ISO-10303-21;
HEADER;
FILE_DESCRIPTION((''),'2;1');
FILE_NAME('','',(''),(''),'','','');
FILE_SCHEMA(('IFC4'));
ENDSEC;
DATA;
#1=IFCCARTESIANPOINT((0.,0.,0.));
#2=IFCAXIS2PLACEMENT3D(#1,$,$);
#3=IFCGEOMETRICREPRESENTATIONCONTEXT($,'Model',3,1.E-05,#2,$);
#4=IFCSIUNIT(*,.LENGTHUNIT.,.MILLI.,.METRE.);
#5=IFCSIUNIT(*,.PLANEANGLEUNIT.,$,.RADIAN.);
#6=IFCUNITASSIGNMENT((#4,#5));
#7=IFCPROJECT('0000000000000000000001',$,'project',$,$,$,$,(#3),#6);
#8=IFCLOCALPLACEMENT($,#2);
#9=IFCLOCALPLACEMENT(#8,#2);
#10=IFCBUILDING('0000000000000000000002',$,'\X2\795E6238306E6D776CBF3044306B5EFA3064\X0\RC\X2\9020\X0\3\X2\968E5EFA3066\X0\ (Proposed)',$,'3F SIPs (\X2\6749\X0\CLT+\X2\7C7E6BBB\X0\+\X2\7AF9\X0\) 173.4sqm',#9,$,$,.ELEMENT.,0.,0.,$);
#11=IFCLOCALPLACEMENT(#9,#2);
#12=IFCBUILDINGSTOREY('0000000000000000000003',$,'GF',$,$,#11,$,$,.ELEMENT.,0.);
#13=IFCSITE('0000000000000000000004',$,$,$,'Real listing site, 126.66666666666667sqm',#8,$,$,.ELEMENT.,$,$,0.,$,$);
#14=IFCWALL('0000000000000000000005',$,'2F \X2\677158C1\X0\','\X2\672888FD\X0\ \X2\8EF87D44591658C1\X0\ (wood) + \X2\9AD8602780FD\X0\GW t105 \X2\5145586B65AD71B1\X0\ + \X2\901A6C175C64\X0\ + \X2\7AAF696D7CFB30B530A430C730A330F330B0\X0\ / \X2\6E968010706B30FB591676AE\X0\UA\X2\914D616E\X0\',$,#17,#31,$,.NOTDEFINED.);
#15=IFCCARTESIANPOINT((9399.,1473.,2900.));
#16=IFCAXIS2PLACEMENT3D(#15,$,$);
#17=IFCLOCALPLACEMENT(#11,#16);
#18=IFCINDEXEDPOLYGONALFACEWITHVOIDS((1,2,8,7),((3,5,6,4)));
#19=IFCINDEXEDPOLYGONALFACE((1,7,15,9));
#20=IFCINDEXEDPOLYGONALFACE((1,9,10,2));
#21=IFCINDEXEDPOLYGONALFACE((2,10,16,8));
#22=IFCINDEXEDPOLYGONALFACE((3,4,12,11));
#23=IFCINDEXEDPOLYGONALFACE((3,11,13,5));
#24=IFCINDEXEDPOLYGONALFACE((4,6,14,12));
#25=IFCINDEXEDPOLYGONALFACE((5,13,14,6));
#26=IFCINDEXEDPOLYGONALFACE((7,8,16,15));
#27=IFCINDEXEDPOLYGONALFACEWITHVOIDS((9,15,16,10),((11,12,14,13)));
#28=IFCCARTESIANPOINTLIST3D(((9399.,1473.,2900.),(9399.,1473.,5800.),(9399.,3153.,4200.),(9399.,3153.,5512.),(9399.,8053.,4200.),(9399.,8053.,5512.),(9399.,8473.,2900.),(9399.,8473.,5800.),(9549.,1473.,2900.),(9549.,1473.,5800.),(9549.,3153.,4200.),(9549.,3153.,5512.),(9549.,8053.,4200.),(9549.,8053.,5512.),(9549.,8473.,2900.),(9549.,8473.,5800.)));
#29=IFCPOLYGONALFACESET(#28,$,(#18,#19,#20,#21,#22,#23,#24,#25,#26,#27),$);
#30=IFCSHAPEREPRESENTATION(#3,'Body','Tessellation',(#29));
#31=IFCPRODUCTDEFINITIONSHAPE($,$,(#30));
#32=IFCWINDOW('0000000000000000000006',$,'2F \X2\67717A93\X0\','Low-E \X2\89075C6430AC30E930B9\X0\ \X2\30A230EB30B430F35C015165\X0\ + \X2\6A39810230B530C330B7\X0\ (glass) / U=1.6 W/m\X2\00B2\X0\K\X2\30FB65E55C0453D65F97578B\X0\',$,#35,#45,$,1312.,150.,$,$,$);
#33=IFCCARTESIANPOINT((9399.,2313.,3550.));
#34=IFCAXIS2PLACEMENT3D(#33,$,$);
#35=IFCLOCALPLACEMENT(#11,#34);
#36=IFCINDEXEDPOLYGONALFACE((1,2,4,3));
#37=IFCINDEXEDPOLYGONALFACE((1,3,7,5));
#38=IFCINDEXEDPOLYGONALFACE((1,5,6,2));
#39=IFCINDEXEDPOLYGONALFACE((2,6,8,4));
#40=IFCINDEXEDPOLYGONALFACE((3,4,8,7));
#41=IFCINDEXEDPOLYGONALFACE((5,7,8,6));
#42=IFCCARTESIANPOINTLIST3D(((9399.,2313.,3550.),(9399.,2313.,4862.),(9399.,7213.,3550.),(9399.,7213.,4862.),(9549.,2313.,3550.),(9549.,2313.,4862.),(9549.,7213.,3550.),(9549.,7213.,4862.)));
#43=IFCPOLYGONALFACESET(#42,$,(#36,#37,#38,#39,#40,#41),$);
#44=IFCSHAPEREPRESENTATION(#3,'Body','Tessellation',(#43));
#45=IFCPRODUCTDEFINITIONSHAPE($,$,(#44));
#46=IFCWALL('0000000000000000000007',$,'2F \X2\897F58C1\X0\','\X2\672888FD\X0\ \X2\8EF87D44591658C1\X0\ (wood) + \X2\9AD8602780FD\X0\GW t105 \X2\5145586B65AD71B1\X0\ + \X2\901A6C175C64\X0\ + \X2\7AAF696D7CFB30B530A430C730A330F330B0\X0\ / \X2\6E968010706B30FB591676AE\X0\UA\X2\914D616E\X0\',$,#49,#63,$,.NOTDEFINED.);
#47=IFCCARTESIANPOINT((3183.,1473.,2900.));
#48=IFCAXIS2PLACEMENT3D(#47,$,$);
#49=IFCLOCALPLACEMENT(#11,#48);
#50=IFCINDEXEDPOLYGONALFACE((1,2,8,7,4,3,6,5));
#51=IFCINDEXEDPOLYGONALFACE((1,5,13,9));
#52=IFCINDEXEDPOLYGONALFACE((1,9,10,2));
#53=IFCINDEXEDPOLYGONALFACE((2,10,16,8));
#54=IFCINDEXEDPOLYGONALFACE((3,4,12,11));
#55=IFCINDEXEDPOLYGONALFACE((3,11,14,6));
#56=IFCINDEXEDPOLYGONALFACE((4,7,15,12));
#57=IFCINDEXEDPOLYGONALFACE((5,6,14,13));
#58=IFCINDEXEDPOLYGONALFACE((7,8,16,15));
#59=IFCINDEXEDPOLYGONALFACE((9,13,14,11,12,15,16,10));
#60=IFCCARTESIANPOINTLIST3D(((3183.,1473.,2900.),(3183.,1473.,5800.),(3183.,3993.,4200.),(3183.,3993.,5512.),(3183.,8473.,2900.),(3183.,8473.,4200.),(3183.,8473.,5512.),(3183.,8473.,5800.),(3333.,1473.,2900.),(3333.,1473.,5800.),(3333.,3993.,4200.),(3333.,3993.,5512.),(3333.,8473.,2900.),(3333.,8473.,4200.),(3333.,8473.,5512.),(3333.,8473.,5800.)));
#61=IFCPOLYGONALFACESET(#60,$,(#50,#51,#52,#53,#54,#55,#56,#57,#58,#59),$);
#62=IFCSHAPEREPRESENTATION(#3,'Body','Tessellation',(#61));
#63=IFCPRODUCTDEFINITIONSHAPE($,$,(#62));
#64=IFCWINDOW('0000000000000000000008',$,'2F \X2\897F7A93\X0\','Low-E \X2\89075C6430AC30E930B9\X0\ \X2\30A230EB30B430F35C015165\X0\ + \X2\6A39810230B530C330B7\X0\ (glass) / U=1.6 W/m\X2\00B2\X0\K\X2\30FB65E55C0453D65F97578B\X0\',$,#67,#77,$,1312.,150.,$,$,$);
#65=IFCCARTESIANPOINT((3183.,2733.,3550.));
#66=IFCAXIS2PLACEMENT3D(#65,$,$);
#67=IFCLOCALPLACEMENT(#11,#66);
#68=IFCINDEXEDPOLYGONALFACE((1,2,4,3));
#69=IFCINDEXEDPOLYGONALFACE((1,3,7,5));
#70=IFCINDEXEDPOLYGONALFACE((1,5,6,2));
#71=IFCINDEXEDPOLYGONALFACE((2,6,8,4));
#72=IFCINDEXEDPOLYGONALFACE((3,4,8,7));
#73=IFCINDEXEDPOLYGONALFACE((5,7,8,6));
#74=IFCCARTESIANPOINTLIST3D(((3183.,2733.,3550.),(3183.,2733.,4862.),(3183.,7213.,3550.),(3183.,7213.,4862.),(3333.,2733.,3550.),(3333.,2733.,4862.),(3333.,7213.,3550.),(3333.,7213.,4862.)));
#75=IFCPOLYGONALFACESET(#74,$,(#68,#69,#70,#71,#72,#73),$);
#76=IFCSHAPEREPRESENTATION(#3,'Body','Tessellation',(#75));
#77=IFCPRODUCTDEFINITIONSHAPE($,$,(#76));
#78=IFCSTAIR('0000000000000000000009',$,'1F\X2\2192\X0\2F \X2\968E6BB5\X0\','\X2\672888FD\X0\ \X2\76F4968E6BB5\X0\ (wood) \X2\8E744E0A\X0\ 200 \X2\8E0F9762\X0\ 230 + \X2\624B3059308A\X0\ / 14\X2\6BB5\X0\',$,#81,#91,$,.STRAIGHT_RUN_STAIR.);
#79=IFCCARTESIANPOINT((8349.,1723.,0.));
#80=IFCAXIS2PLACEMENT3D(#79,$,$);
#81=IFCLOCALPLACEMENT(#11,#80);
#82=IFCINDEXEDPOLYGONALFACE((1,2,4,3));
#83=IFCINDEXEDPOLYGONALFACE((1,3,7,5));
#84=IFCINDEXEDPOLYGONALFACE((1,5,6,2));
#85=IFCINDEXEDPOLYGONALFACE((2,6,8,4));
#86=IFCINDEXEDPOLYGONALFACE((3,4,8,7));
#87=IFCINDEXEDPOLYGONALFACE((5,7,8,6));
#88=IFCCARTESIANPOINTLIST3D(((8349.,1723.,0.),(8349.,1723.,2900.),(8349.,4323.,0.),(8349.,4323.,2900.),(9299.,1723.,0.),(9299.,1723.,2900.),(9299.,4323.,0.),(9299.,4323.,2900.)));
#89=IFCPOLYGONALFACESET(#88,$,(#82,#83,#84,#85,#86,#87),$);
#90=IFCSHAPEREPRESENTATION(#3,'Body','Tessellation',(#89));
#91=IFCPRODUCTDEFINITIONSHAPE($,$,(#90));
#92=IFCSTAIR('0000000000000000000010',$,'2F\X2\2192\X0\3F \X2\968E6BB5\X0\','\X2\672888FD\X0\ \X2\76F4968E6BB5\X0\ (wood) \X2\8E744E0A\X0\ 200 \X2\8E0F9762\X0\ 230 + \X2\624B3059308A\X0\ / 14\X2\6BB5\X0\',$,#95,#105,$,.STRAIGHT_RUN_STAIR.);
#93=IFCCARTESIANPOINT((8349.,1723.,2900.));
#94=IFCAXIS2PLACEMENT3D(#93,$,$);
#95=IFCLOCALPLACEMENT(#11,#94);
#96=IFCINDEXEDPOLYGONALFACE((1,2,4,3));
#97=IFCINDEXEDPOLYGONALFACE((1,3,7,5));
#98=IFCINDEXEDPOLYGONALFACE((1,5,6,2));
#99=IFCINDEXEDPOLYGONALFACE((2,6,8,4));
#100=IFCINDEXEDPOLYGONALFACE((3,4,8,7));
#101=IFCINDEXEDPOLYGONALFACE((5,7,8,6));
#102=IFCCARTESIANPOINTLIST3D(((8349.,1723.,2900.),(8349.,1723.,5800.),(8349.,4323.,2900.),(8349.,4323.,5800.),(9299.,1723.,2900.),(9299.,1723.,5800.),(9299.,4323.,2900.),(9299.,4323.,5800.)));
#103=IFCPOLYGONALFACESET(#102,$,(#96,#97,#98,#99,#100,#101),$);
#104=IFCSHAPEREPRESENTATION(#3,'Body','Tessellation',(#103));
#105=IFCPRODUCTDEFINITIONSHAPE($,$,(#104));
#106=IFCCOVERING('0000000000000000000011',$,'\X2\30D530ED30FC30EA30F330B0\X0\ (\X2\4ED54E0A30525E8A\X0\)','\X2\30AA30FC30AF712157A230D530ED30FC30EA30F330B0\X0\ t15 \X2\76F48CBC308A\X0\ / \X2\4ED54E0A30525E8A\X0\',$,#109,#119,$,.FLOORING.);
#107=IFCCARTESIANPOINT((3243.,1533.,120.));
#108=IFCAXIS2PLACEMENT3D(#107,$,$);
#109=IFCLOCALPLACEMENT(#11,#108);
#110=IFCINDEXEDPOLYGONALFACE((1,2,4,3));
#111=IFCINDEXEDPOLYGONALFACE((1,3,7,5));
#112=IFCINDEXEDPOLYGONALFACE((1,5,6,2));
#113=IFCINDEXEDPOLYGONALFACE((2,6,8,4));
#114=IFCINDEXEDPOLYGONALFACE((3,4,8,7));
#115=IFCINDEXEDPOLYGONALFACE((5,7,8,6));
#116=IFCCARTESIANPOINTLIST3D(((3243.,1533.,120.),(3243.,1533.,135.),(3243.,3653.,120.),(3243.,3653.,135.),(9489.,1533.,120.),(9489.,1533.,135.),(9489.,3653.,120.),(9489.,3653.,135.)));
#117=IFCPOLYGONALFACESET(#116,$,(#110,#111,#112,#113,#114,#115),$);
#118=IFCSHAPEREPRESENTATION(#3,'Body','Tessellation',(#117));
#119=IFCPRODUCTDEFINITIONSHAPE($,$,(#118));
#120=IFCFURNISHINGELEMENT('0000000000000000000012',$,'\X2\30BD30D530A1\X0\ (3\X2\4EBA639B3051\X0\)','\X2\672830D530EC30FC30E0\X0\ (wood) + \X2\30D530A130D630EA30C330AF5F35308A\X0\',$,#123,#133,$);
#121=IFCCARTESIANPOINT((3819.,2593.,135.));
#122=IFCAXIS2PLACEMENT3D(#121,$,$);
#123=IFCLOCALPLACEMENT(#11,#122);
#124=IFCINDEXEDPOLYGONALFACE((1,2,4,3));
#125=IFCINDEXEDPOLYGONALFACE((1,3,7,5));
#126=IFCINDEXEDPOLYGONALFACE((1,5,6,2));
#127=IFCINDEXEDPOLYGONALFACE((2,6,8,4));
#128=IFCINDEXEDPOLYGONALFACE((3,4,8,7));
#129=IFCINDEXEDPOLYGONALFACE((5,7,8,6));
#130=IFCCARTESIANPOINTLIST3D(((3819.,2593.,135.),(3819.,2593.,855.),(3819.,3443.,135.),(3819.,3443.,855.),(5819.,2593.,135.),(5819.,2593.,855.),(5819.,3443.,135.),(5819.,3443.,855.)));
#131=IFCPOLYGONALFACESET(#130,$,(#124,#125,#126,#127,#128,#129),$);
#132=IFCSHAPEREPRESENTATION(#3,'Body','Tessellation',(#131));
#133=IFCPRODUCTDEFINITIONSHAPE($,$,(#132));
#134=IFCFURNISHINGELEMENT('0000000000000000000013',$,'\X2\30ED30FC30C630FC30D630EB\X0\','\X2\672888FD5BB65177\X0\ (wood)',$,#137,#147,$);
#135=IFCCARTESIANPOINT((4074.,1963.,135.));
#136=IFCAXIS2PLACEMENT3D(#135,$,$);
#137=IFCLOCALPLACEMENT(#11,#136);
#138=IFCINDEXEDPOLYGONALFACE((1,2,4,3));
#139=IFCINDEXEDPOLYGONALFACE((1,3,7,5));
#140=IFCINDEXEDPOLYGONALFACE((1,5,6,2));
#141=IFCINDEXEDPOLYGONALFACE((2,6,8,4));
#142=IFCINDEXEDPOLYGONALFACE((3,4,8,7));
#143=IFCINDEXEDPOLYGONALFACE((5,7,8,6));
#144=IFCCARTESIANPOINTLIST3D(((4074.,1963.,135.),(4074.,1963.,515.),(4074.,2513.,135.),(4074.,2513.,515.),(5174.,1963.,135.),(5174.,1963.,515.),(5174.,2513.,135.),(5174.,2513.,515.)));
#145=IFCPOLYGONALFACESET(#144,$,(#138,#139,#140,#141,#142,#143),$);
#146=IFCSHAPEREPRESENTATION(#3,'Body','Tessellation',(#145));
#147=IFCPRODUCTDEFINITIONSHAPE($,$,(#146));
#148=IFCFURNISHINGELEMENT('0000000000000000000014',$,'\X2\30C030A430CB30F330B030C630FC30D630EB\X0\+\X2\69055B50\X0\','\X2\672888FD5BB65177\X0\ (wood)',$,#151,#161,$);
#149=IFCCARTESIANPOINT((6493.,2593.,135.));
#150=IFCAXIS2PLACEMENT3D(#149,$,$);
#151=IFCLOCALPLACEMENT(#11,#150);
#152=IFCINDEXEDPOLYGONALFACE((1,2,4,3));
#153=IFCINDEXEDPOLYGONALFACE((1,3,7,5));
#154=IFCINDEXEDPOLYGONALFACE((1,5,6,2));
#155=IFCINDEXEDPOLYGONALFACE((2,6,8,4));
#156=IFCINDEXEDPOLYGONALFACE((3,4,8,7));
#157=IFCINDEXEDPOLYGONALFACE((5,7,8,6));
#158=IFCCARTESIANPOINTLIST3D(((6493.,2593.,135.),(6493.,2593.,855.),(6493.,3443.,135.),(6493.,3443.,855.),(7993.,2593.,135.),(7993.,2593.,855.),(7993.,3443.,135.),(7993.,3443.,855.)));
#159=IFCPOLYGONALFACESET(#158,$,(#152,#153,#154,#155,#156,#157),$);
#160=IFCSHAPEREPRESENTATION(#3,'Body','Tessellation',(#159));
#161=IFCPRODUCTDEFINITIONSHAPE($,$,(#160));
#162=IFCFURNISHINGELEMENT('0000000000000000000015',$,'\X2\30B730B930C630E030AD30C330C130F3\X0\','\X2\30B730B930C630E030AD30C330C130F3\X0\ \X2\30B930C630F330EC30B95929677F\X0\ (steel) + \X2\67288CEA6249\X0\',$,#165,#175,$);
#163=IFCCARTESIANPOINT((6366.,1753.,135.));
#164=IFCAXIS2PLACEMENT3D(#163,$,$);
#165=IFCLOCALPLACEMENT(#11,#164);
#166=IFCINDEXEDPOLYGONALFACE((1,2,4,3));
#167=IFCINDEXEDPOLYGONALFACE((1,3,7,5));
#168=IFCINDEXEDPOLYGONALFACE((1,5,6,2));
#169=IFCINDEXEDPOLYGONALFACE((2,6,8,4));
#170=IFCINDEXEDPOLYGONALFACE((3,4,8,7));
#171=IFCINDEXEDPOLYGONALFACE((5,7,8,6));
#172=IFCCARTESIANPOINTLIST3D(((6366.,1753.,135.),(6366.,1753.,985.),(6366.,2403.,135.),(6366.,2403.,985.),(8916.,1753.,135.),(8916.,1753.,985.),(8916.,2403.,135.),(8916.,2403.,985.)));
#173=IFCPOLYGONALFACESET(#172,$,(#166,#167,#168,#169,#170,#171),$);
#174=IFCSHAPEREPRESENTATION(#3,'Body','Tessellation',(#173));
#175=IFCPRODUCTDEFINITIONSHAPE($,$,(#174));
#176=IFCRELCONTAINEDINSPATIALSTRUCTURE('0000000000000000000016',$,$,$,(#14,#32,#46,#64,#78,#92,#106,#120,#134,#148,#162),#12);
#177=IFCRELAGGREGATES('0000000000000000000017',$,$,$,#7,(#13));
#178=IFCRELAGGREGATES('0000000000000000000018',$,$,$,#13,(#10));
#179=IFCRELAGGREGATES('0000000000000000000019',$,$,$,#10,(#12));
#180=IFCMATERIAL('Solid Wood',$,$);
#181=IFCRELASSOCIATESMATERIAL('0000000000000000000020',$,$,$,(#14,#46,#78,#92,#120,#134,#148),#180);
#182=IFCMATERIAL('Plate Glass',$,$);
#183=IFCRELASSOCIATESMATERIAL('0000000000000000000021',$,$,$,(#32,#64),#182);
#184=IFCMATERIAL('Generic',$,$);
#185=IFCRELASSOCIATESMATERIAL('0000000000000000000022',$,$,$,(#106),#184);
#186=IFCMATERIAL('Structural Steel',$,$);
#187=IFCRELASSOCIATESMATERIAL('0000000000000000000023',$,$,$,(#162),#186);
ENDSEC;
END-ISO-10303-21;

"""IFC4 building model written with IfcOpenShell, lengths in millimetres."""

from ifc_helpers import new_model, si_unit, frame, frame_2d, origin, place, context, project, spatial, rectangle, extrude, material, element, fill, save


model = new_model("IFC4")

# Units and contexts
model_context = context("Model", 3, precision=1e-05, world=origin())
ifc_project = project(units=[si_unit("LENGTHUNIT", "METRE", prefix="MILLI"), si_unit("PLANEANGLEUNIT", "RADIAN")], contexts=[model_context])

# Site, building, storey
site_placement = place(None, origin())
site = spatial("IfcSite", under=ifc_project, at=site_placement, ObjectType="Real listing site, 126.66666666666667sqm", CompositionType="ELEMENT", RefElevation=0.0)
building_placement = place(site_placement, origin())
building = spatial("IfcBuilding", under=site, at=building_placement, Name="神戸の海沿いに建つRC造3階建て (Proposed)", ObjectType="3F SIPs (杉CLT+籾殻+竹) 173.4sqm", CompositionType="ELEMENT", ElevationOfRefHeight=0.0, ElevationOfTerrain=0.0)
storey_placement = place(building_placement, origin())
storey = spatial("IfcBuildingStorey", under=building, at=storey_placement, Name="GF", CompositionType="ELEMENT", Elevation=0.0)

# Shared definitions
ifc_material_1 = material(Name="Solid Wood")
ifc_material_2 = material(Name="Generic")

# Shared definitions
ifc_material_3 = material(Name="Plate Glass")

# Walls, openings, windows
wall_1_placement = place(storey_placement, frame((9399.0, 1473.0, 2900.0)))
wall_1 = element("IfcWall", 1, at=wall_1_placement, inside=storey, material=ifc_material_1, Name="2F 東壁", Description="木製 軸組外壁 (wood) + 高性能GW t105 充填断熱 + 通気層 + 窯業系サイディング / 準耐火・外皮UA配慮", PredefinedType="NOTDEFINED", context=model_context, shape_type="SweptSolid", body=[
    extrude(rectangle(XDim=150.0, YDim=7000.0, at=frame_2d((75.0, 3500.0))), frame((9399.0, 1473.0, 2900.0)), (0.0, 0.0, 1.0), 2900.0),
])
opening_1_placement = place(storey_placement, frame((9399.0, 2313.0, 3550.0)))
opening_1 = element("IfcOpeningElement", 2, at=opening_1_placement, cuts=wall_1, PredefinedType="NOTDEFINED", context=model_context, shape_type="SweptSolid", body=[
    extrude(rectangle(XDim=150.0, YDim=4900.0, at=frame_2d((75.0, 2450.0))), frame((9399.0, 2313.0, 3550.0)), (0.0, 0.0, 1.0), 1312.0),
])
window_1_placement = place(storey_placement, frame((9399.0, 2313.0, 3550.0)))
window_1 = element("IfcWindow", 3, at=window_1_placement, inside=storey, material=ifc_material_3, Name="2F 東窓", Description="Low-E 複層ガラス アルゴン封入 + 樹脂サッシ (glass) / U=1.6 W/m²K・日射取得型", OverallHeight=1312.0, OverallWidth=150.0, context=model_context, shape_type="SweptSolid", body=[
    extrude(rectangle(XDim=150.0, YDim=4900.0, at=frame_2d((75.0, 2450.0))), frame((9399.0, 2313.0, 3550.0)), (0.0, 0.0, 1.0), 1312.0),
])
fill(opening_1, window_1)
wall_2_placement = place(storey_placement, frame((3183.0, 1473.0, 2900.0)))
wall_2 = element("IfcWall", 4, at=wall_2_placement, inside=storey, material=ifc_material_1, Name="2F 西壁", Description="木製 軸組外壁 (wood) + 高性能GW t105 充填断熱 + 通気層 + 窯業系サイディング / 準耐火・外皮UA配慮", PredefinedType="NOTDEFINED", context=model_context, shape_type="SweptSolid", body=[
    extrude(rectangle(XDim=150.0, YDim=7000.0, at=frame_2d((75.0, 3500.0))), frame((3183.0, 1473.0, 2900.0)), (0.0, 0.0, 1.0), 2900.0),
])
opening_2_placement = place(storey_placement, frame((3183.0, 2733.0, 3550.0)))
opening_2 = element("IfcOpeningElement", 5, at=opening_2_placement, cuts=wall_2, PredefinedType="NOTDEFINED", context=model_context, shape_type="SweptSolid", body=[
    extrude(rectangle(XDim=150.0, YDim=4480.0, at=frame_2d((75.0, 2240.0))), frame((3183.0, 2733.0, 3550.0)), (0.0, 0.0, 1.0), 1312.0),
])
window_2_placement = place(storey_placement, frame((3183.0, 2733.0, 3550.0)))
window_2 = element("IfcWindow", 6, at=window_2_placement, inside=storey, material=ifc_material_3, Name="2F 西窓", Description="Low-E 複層ガラス アルゴン封入 + 樹脂サッシ (glass) / U=1.6 W/m²K・日射取得型", OverallHeight=1312.0, OverallWidth=150.0, context=model_context, shape_type="SweptSolid", body=[
    extrude(rectangle(XDim=150.0, YDim=4480.0, at=frame_2d((75.0, 2240.0))), frame((3183.0, 2733.0, 3550.0)), (0.0, 0.0, 1.0), 1312.0),
])
fill(opening_2, window_2)

# Stairs
stair_1_placement = place(storey_placement, frame((8349.0, 1723.0, 0.0)))
element("IfcStair", 7, at=stair_1_placement, inside=storey, material=ifc_material_1, Name="1F→2F 階段", Description="木製 直階段 (wood) 蹴上 200 踏面 230 + 手すり / 14段", PredefinedType="STRAIGHT_RUN_STAIR", context=model_context, shape_type="SweptSolid", body=[
    extrude(rectangle(XDim=950.0, YDim=2600.0, at=frame_2d((475.0, 1300.0))), frame((8349.0, 1723.0, 0.0)), (0.0, 0.0, 1.0), 2900.0),
])
stair_2_placement = place(storey_placement, frame((8349.0, 1723.0, 2900.0)))
element("IfcStair", 8, at=stair_2_placement, inside=storey, material=ifc_material_1, Name="2F→3F 階段", Description="木製 直階段 (wood) 蹴上 200 踏面 230 + 手すり / 14段", PredefinedType="STRAIGHT_RUN_STAIR", context=model_context, shape_type="SweptSolid", body=[
    extrude(rectangle(XDim=950.0, YDim=2600.0, at=frame_2d((475.0, 1300.0))), frame((8349.0, 1723.0, 2900.0)), (0.0, 0.0, 1.0), 2900.0),
])

# Covering
covering_placement = place(storey_placement, frame((3243.0, 1533.0, 120.0)))
element("IfcCovering", 9, at=covering_placement, inside=storey, material=ifc_material_2, Name="フローリング (仕上げ床)", Description="オーク無垢フローリング t15 直貼り / 仕上げ床", PredefinedType="FLOORING", context=model_context, shape_type="SweptSolid", body=[
    extrude(rectangle(XDim=6246.0, YDim=2120.0, at=frame_2d((3123.0, 1060.0))), frame((3243.0, 1533.0, 120.0)), (0.0, 0.0, 1.0), 15.0),
])

# Furnishing elements
furnishing_1_placement = place(storey_placement, frame((3819.0, 2593.0, 135.0)))
element("IfcFurnishingElement", 10, at=furnishing_1_placement, inside=storey, material=ifc_material_1, Name="ソファ (3人掛け)", Description="木フレーム (wood) + ファブリック張り", context=model_context, shape_type="SweptSolid", body=[
    extrude(rectangle(XDim=2000.0, YDim=850.0, at=frame_2d((1000.0, 425.0))), frame((3819.0, 2593.0, 135.0)), (0.0, 0.0, 1.0), 720.0),
])
furnishing_2_placement = place(storey_placement, frame((4074.0, 1963.0, 135.0)))
element("IfcFurnishingElement", 11, at=furnishing_2_placement, inside=storey, material=ifc_material_1, Name="ローテーブル", Description="木製家具 (wood)", context=model_context, shape_type="SweptSolid", body=[
    extrude(rectangle(XDim=1100.0, YDim=550.0, at=frame_2d((550.0, 275.0))), frame((4074.0, 1963.0, 135.0)), (0.0, 0.0, 1.0), 380.0),
])
furnishing_3_placement = place(storey_placement, frame((6493.0, 2593.0, 135.0)))
element("IfcFurnishingElement", 12, at=furnishing_3_placement, inside=storey, material=ifc_material_1, Name="ダイニングテーブル+椅子", Description="木製家具 (wood)", context=model_context, shape_type="SweptSolid", body=[
    extrude(rectangle(XDim=1500.0, YDim=850.0, at=frame_2d((750.0, 425.0))), frame((6493.0, 2593.0, 135.0)), (0.0, 0.0, 1.0), 720.0),
])
ifc_material_4 = material(Name="Structural Steel")
furnishing_4_placement = place(storey_placement, frame((6366.0, 1753.0, 135.0)))
element("IfcFurnishingElement", 13, at=furnishing_4_placement, inside=storey, material=ifc_material_4, Name="システムキッチン", Description="システムキッチン ステンレス天板 (steel) + 木質扉", context=model_context, shape_type="SweptSolid", body=[
    extrude(rectangle(XDim=2550.0, YDim=650.0, at=frame_2d((1275.0, 325.0))), frame((6366.0, 1753.0, 135.0)), (0.0, 0.0, 1.0), 850.0),
])

save(model, "model.ifc")
